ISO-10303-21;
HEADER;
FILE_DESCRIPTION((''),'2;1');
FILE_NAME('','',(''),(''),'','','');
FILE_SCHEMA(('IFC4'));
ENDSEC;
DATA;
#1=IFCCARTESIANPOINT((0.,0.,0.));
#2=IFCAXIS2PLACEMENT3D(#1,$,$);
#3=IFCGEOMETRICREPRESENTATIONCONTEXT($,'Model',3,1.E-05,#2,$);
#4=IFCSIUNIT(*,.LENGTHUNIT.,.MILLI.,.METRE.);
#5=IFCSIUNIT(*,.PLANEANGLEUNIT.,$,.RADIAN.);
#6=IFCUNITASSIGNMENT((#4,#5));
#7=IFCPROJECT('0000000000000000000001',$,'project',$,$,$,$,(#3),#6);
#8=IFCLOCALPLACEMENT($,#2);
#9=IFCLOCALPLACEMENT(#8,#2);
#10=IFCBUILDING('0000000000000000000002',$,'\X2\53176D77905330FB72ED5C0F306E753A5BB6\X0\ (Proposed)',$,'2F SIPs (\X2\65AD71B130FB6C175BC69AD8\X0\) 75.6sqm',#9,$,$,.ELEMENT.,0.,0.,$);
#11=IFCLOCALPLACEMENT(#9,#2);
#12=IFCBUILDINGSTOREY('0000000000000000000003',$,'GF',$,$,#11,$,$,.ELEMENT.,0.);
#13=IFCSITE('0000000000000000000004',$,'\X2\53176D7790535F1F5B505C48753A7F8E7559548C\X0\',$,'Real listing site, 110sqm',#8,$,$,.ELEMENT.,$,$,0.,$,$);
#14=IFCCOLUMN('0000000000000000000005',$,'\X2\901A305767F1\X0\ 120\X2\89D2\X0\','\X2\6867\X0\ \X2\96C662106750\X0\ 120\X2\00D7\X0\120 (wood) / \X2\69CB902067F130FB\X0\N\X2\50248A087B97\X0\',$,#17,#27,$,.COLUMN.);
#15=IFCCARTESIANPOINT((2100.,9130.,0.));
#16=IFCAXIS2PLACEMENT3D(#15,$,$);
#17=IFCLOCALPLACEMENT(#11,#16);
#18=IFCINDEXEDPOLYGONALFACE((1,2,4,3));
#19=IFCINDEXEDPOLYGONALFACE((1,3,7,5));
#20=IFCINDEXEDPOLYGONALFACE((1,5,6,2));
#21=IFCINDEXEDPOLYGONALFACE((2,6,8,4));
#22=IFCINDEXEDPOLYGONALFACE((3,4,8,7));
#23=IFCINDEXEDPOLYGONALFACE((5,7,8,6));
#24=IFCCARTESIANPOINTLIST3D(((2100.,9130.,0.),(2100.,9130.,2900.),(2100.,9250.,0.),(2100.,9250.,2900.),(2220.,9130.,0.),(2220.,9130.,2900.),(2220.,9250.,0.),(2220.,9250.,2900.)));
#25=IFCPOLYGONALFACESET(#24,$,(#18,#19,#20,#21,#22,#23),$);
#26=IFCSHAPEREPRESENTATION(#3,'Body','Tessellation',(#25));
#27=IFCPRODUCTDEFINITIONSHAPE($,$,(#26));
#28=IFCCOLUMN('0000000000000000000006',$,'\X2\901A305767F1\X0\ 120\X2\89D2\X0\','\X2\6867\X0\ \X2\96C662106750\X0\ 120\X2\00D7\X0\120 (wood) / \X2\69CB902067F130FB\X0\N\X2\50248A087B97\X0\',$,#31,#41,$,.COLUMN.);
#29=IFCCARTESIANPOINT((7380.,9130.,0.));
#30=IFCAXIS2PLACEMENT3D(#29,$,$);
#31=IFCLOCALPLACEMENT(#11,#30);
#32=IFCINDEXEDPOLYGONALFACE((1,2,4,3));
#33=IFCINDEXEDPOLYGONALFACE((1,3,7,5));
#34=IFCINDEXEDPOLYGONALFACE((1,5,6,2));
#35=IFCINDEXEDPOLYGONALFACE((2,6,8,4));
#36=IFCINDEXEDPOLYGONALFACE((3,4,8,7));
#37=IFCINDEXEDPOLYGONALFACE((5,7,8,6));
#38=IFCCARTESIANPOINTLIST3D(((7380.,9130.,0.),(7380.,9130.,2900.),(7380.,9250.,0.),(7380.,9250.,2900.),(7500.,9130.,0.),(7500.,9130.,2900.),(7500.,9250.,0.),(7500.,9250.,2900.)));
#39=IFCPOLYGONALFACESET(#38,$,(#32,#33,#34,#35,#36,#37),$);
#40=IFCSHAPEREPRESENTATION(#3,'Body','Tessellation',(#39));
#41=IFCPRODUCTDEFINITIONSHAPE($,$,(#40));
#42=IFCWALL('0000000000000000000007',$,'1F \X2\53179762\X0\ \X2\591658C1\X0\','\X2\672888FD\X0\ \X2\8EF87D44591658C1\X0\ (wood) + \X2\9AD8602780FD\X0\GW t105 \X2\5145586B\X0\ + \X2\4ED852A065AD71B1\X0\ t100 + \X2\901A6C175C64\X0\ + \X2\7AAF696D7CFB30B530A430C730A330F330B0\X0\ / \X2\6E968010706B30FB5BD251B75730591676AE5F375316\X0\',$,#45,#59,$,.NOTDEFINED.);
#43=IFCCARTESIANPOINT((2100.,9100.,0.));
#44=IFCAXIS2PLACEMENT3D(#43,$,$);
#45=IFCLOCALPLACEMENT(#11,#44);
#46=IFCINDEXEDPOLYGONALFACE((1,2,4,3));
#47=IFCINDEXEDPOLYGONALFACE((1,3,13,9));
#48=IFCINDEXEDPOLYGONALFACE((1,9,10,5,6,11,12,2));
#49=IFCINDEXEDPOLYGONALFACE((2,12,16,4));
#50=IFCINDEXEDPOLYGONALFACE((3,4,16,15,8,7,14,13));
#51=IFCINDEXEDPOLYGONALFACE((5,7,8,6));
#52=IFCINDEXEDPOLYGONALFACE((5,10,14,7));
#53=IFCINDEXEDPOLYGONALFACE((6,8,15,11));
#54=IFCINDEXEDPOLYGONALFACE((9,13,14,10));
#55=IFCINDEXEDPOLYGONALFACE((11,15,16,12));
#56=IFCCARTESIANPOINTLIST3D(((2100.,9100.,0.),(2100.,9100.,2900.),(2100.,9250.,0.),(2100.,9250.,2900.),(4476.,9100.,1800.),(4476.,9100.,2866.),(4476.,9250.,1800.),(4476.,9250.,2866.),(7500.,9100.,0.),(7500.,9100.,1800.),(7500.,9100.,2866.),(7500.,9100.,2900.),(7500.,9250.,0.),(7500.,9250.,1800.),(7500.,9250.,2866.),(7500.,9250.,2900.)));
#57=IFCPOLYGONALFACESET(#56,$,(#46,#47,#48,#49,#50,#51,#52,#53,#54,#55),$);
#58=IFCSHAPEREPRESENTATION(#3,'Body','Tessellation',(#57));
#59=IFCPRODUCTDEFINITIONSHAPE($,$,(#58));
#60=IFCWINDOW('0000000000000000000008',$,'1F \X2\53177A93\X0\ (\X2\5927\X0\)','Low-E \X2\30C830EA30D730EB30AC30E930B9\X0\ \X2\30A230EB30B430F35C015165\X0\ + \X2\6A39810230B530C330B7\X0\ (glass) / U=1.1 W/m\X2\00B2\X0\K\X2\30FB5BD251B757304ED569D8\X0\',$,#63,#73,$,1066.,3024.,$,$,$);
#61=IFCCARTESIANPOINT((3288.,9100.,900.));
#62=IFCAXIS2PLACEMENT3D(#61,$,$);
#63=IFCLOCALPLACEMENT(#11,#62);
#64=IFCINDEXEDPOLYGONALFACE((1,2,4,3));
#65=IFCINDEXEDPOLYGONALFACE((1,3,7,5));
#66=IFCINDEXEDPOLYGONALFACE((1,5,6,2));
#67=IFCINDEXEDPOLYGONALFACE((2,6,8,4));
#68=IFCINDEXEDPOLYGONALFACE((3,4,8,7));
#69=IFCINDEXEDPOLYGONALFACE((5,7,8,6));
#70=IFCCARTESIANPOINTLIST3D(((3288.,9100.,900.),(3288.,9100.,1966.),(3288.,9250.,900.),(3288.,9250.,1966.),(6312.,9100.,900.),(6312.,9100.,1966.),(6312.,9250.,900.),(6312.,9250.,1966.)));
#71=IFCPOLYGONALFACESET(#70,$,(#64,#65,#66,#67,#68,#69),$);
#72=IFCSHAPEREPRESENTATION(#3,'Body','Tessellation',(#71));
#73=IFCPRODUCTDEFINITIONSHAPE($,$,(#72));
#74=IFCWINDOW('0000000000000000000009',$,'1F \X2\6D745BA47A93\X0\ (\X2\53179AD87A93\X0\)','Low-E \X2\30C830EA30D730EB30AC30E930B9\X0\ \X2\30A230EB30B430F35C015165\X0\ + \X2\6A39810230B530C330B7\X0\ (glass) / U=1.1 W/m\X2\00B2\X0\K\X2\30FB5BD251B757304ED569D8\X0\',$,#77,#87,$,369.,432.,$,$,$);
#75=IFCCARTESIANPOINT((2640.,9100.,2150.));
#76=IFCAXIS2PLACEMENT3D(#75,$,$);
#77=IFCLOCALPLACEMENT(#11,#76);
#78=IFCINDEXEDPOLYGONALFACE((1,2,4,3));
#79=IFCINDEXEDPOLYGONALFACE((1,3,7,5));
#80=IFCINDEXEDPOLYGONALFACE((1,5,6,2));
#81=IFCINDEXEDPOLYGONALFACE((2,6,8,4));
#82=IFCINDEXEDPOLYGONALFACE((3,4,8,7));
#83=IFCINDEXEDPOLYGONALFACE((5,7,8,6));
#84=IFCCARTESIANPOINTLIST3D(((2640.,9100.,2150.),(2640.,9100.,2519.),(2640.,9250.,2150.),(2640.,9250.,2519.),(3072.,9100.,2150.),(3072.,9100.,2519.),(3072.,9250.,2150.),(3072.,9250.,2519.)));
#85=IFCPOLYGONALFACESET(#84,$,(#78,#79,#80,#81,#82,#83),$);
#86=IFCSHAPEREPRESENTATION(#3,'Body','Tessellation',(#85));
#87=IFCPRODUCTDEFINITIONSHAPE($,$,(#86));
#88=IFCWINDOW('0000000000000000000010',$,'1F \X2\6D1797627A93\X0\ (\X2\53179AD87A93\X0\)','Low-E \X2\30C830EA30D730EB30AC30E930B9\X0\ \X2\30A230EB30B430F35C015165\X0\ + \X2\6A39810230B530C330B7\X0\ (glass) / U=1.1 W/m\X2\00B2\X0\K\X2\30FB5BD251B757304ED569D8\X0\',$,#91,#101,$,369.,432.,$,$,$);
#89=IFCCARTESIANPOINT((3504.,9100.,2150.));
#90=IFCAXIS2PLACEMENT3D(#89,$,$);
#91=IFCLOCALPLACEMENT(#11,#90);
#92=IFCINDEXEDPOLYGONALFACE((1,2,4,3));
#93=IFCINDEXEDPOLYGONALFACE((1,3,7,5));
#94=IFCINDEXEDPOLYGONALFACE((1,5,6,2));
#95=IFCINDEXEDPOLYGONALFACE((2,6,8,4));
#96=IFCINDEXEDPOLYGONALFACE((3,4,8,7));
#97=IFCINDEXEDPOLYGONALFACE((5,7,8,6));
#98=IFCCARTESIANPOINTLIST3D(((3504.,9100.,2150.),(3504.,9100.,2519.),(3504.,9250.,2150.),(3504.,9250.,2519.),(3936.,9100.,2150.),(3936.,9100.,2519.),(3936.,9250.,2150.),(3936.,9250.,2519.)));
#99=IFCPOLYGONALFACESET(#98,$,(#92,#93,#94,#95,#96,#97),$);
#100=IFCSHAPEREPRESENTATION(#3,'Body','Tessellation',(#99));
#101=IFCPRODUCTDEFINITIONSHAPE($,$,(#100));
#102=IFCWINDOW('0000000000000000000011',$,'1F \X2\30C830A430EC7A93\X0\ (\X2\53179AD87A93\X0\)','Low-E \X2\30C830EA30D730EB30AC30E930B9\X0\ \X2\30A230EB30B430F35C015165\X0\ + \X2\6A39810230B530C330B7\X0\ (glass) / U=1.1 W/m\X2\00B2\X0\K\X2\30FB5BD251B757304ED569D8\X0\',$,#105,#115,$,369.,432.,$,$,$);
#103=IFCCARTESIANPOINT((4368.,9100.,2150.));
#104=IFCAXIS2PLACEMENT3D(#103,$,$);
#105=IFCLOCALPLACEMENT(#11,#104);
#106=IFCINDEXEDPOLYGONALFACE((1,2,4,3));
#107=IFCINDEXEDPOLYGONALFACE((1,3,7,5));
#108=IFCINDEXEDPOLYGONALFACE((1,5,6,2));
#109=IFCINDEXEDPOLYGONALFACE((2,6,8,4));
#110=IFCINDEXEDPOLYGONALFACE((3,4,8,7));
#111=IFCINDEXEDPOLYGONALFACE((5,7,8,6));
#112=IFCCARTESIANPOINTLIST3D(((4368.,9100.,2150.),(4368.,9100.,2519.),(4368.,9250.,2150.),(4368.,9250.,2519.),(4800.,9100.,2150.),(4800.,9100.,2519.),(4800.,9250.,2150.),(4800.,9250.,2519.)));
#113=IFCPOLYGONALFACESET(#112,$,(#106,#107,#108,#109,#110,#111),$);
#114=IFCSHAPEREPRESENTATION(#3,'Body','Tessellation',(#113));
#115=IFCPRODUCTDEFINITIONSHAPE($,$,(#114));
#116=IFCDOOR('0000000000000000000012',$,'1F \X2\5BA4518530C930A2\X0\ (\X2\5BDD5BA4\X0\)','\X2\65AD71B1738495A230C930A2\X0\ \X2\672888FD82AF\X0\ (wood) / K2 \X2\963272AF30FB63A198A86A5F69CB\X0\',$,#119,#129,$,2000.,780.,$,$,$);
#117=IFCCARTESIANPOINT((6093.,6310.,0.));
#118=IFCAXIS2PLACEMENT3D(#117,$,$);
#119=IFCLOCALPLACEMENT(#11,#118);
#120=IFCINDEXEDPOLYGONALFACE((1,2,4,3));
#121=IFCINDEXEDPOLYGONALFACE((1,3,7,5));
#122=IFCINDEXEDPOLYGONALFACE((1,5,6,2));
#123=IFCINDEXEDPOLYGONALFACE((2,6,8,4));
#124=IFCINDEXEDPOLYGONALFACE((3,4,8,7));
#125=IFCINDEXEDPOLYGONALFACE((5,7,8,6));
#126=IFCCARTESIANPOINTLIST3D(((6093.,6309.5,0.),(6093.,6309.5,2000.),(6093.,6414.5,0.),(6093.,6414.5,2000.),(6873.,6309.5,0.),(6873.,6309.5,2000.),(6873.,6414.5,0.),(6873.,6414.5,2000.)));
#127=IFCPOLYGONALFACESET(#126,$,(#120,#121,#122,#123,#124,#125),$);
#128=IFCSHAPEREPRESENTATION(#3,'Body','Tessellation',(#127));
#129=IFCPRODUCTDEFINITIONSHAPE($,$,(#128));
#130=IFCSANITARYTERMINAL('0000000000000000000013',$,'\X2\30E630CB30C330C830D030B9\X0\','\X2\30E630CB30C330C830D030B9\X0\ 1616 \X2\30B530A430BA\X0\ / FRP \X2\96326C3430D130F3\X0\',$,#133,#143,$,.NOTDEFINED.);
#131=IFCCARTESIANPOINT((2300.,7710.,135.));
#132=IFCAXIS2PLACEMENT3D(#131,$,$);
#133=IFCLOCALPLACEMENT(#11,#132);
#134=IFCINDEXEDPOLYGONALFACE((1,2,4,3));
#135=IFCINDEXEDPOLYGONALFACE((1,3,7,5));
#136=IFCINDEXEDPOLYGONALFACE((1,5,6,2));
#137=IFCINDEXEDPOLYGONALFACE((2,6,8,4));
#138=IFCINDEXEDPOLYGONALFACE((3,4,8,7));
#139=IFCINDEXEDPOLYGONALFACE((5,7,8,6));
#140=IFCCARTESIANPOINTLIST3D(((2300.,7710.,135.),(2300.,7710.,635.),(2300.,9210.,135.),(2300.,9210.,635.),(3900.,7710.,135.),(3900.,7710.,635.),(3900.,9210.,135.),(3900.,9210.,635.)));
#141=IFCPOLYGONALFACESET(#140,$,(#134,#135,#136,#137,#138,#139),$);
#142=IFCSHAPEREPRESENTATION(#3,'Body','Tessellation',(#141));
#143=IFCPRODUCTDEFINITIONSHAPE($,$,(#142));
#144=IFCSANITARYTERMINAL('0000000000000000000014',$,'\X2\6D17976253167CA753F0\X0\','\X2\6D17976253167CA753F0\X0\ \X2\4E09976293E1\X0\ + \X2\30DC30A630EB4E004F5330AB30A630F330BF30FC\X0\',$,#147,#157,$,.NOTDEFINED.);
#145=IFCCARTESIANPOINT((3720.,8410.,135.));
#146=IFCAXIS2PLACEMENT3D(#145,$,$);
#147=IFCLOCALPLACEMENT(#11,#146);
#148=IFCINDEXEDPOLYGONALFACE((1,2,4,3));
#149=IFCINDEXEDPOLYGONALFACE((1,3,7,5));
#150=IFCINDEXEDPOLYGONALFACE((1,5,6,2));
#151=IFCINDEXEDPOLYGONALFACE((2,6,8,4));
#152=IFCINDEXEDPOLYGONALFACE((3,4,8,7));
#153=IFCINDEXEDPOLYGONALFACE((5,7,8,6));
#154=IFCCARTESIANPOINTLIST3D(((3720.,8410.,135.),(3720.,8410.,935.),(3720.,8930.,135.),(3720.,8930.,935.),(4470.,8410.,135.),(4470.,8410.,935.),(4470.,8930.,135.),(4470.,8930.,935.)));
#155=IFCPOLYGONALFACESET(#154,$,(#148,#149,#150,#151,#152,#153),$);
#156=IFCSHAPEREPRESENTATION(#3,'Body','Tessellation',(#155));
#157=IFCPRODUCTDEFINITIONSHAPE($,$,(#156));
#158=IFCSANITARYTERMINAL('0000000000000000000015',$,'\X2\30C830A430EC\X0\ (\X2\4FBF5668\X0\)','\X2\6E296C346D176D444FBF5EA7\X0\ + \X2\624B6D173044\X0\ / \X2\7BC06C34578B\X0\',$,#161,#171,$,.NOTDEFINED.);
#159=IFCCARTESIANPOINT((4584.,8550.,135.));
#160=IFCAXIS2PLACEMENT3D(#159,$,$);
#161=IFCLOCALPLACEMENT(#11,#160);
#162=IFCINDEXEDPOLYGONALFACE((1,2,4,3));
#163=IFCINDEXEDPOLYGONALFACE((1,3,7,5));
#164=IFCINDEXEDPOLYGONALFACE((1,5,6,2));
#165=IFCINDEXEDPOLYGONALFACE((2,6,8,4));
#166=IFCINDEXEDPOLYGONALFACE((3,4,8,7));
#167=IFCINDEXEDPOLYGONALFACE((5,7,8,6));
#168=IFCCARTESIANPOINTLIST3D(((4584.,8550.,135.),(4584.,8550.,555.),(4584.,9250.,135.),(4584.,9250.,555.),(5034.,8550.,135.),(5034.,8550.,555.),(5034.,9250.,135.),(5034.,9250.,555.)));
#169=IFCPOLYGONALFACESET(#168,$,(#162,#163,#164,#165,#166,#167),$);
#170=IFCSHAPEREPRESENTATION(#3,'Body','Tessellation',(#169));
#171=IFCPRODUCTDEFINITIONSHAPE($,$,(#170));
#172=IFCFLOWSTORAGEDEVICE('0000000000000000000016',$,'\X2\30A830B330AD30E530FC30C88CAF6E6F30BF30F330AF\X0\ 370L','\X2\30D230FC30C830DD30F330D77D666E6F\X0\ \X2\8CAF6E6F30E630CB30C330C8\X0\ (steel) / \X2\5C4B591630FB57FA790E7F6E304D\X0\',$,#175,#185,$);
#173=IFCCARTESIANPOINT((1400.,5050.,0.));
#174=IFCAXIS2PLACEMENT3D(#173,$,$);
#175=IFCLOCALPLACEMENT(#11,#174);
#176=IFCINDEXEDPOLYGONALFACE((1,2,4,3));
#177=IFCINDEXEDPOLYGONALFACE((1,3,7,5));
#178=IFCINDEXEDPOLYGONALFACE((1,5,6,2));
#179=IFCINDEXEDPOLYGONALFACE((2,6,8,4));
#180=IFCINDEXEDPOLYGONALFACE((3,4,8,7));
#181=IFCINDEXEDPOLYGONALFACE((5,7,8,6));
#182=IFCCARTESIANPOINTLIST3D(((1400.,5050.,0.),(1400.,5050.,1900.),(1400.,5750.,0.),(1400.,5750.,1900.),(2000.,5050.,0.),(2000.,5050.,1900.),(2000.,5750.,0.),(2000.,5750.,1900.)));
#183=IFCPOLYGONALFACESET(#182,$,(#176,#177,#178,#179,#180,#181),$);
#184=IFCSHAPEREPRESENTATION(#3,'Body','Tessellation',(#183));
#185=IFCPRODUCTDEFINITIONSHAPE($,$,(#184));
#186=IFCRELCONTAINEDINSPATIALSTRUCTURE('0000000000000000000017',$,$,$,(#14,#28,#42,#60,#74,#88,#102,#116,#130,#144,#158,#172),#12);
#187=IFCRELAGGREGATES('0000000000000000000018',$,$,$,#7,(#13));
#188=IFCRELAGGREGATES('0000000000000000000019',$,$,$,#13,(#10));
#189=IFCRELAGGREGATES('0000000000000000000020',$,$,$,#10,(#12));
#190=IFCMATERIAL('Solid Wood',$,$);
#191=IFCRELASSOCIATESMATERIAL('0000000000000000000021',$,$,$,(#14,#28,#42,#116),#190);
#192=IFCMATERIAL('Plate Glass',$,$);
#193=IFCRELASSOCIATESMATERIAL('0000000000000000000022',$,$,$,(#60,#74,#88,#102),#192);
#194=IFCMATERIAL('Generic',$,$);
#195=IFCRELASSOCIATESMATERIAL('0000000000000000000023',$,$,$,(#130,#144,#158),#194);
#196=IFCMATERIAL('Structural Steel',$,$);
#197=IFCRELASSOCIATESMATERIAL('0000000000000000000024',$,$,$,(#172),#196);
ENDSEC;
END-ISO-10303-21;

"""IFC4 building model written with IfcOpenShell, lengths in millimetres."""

from ifc_helpers import new_model, si_unit, frame, frame_2d, origin, place, context, project, spatial, rectangle, extrude, material, element, fill, save


model = new_model("IFC4")

# Units and contexts
model_context = context("Model", 3, precision=1e-05, world=origin())
ifc_project = project(units=[si_unit("LENGTHUNIT", "METRE", prefix="MILLI"), si_unit("PLANEANGLEUNIT", "RADIAN")], contexts=[model_context])

# Site, building, storey
site_placement = place(None, origin())
site = spatial("IfcSite", under=ifc_project, at=site_placement, Name="北海道弟子屈町美留和", ObjectType="Real listing site, 110sqm", CompositionType="ELEMENT", RefElevation=0.0)
building_placement = place(site_placement, origin())
building = spatial("IfcBuilding", under=site, at=building_placement, Name="北海道・狭小の町家 (Proposed)", ObjectType="2F SIPs (断熱・気密高) 75.6sqm", CompositionType="ELEMENT", ElevationOfRefHeight=0.0, ElevationOfTerrain=0.0)
storey_placement = place(building_placement, origin())
storey = spatial("IfcBuildingStorey", under=building, at=storey_placement, Name="GF", CompositionType="ELEMENT", Elevation=0.0)

# Columns
ifc_material_1 = material(Name="Solid Wood")
column_1_placement = place(storey_placement, frame((2100.0, 9130.0, 0.0)))
element("IfcColumn", 1, at=column_1_placement, inside=storey, material=ifc_material_1, Name="通し柱 120角", Description="桧 集成材 120×120 (wood) / 構造柱・N値計算", PredefinedType="COLUMN", context=model_context, shape_type="SweptSolid", body=[
    extrude(rectangle(XDim=120.0, YDim=120.0, at=frame_2d((60.0, 60.0))), frame((2100.0, 9130.0, 0.0)), (0.0, 0.0, 1.0), 2900.0),
])
column_2_placement = place(storey_placement, frame((7380.0, 9130.0, 0.0)))
element("IfcColumn", 2, at=column_2_placement, inside=storey, material=ifc_material_1, Name="通し柱 120角", Description="桧 集成材 120×120 (wood) / 構造柱・N値計算", PredefinedType="COLUMN", context=model_context, shape_type="SweptSolid", body=[
    extrude(rectangle(XDim=120.0, YDim=120.0, at=frame_2d((60.0, 60.0))), frame((7380.0, 9130.0, 0.0)), (0.0, 0.0, 1.0), 2900.0),
])

# Wall, openings, windows
wall_1_placement = place(storey_placement, frame((2100.0, 9100.0, 0.0)))
wall_1 = element("IfcWall", 3, at=wall_1_placement, inside=storey, material=ifc_material_1, Name="1F 北面 外壁", Description="木製 軸組外壁 (wood) + 高性能GW t105 充填 + 付加断熱 t100 + 通気層 + 窯業系サイディング / 準耐火・寒冷地外皮強化", PredefinedType="NOTDEFINED", context=model_context, shape_type="SweptSolid", body=[
    extrude(rectangle(XDim=5400.0, YDim=150.0, at=frame_2d((2700.0, 75.0))), frame((2100.0, 9100.0, 0.0)), (0.0, 0.0, 1.0), 2900.0),
])
opening_1_placement = place(storey_placement, frame((3288.0, 9100.0, 900.0)))
opening_1 = element("IfcOpeningElement", 4, at=opening_1_placement, cuts=wall_1, PredefinedType="NOTDEFINED", context=model_context, shape_type="SweptSolid", body=[
    extrude(rectangle(XDim=3024.0, YDim=150.0, at=frame_2d((1512.0, 75.0))), frame((3288.0, 9100.0, 900.0)), (0.0, 0.0, 1.0), 1066.0),
])
opening_2_placement = place(storey_placement, frame((2640.0, 9100.0, 2150.0)))
opening_2 = element("IfcOpeningElement", 5, at=opening_2_placement, cuts=wall_1, PredefinedType="NOTDEFINED", context=model_context, shape_type="SweptSolid", body=[
    extrude(rectangle(XDim=432.0, YDim=150.0, at=frame_2d((216.0, 75.0))), frame((2640.0, 9100.0, 2150.0)), (0.0, 0.0, 1.0), 369.0),
])
opening_3_placement = place(storey_placement, frame((3504.0, 9100.0, 2150.0)))
opening_3 = element("IfcOpeningElement", 6, at=opening_3_placement, cuts=wall_1, PredefinedType="NOTDEFINED", context=model_context, shape_type="SweptSolid", body=[
    extrude(rectangle(XDim=432.0, YDim=150.0, at=frame_2d((216.0, 75.0))), frame((3504.0, 9100.0, 2150.0)), (0.0, 0.0, 1.0), 369.0),
])
opening_4_placement = place(storey_placement, frame((4368.0, 9100.0, 2150.0)))
opening_4 = element("IfcOpeningElement", 7, at=opening_4_placement, cuts=wall_1, PredefinedType="NOTDEFINED", context=model_context, shape_type="SweptSolid", body=[
    extrude(rectangle(XDim=432.0, YDim=150.0, at=frame_2d((216.0, 75.0))), frame((4368.0, 9100.0, 2150.0)), (0.0, 0.0, 1.0), 369.0),
])
ifc_material_2 = material(Name="Plate Glass")
window_1_placement = place(storey_placement, frame((3288.0, 9100.0, 900.0)))
window_1 = element("IfcWindow", 8, at=window_1_placement, inside=storey, material=ifc_material_2, Name="1F 北窓 (大)", Description="Low-E トリプルガラス アルゴン封入 + 樹脂サッシ (glass) / U=1.1 W/m²K・寒冷地仕様", OverallHeight=1066.0, OverallWidth=3024.0, context=model_context, shape_type="SweptSolid", body=[
    extrude(rectangle(XDim=3024.0, YDim=150.0, at=frame_2d((1512.0, 75.0))), frame((3288.0, 9100.0, 900.0)), (0.0, 0.0, 1.0), 1066.0),
])
fill(opening_1, window_1)
window_2_placement = place(storey_placement, frame((2640.0, 9100.0, 2150.0)))
window_2 = element("IfcWindow", 9, at=window_2_placement, inside=storey, material=ifc_material_2, Name="1F 浴室窓 (北高窓)", Description="Low-E トリプルガラス アルゴン封入 + 樹脂サッシ (glass) / U=1.1 W/m²K・寒冷地仕様", OverallHeight=369.0, OverallWidth=432.0, context=model_context, shape_type="SweptSolid", body=[
    extrude(rectangle(XDim=432.0, YDim=150.0, at=frame_2d((216.0, 75.0))), frame((2640.0, 9100.0, 2150.0)), (0.0, 0.0, 1.0), 369.0),
])
fill(opening_2, window_2)
window_3_placement = place(storey_placement, frame((3504.0, 9100.0, 2150.0)))
window_3 = element("IfcWindow", 10, at=window_3_placement, inside=storey, material=ifc_material_2, Name="1F 洗面窓 (北高窓)", Description="Low-E トリプルガラス アルゴン封入 + 樹脂サッシ (glass) / U=1.1 W/m²K・寒冷地仕様", OverallHeight=369.0, OverallWidth=432.0, context=model_context, shape_type="SweptSolid", body=[
    extrude(rectangle(XDim=432.0, YDim=150.0, at=frame_2d((216.0, 75.0))), frame((3504.0, 9100.0, 2150.0)), (0.0, 0.0, 1.0), 369.0),
])
fill(opening_3, window_3)
window_4_placement = place(storey_placement, frame((4368.0, 9100.0, 2150.0)))
window_4 = element("IfcWindow", 11, at=window_4_placement, inside=storey, material=ifc_material_2, Name="1F トイレ窓 (北高窓)", Description="Low-E トリプルガラス アルゴン封入 + 樹脂サッシ (glass) / U=1.1 W/m²K・寒冷地仕様", OverallHeight=369.0, OverallWidth=432.0, context=model_context, shape_type="SweptSolid", body=[
    extrude(rectangle(XDim=432.0, YDim=150.0, at=frame_2d((216.0, 75.0))), frame((4368.0, 9100.0, 2150.0)), (0.0, 0.0, 1.0), 369.0),
])
fill(opening_4, window_4)

# Door
door_1_placement = place(storey_placement, frame((6093.0, 6310.0, 0.0)))
element("IfcDoor", 12, at=door_1_placement, inside=storey, material=ifc_material_1, Name="1F 室内ドア (寝室)", Description="断熱玄関ドア 木製芯 (wood) / K2 防犯・採風機構", OverallHeight=2000.0, OverallWidth=780.0, context=model_context, shape_type="SweptSolid", body=[
    extrude(rectangle(XDim=780.0, YDim=105.0, at=frame_2d((390.0, 52.0))), frame((6093.0, 6310.0, 0.0)), (0.0, 0.0, 1.0), 2000.0),
])

# Sanitary terminals
ifc_material_3 = material(Name="Generic")
sanitary_terminal_1_placement = place(storey_placement, frame((2300.0, 7710.0, 135.0)))
element("IfcSanitaryTerminal", 13, at=sanitary_terminal_1_placement, inside=storey, material=ifc_material_3, Name="ユニットバス", Description="ユニットバス 1616 サイズ / FRP 防水パン", PredefinedType="NOTDEFINED", context=model_context, shape_type="SweptSolid", body=[
    extrude(rectangle(XDim=1600.0, YDim=1500.0, at=frame_2d((800.0, 750.0))), frame((2300.0, 7710.0, 135.0)), (0.0, 0.0, 1.0), 500.0),
])
sanitary_terminal_2_placement = place(storey_placement, frame((3720.0, 8410.0, 135.0)))
element("IfcSanitaryTerminal", 14, at=sanitary_terminal_2_placement, inside=storey, material=ifc_material_3, Name="洗面化粧台", Description="洗面化粧台 三面鏡 + ボウル一体カウンター", PredefinedType="NOTDEFINED", context=model_context, shape_type="SweptSolid", body=[
    extrude(rectangle(XDim=750.0, YDim=520.0, at=frame_2d((375.0, 260.0))), frame((3720.0, 8410.0, 135.0)), (0.0, 0.0, 1.0), 800.0),
])
sanitary_terminal_3_placement = place(storey_placement, frame((4584.0, 8550.0, 135.0)))
element("IfcSanitaryTerminal", 15, at=sanitary_terminal_3_placement, inside=storey, material=ifc_material_3, Name="トイレ (便器)", Description="温水洗浄便座 + 手洗い / 節水型", PredefinedType="NOTDEFINED", context=model_context, shape_type="SweptSolid", body=[
    extrude(rectangle(XDim=450.0, YDim=700.0, at=frame_2d((225.0, 350.0))), frame((4584.0, 8550.0, 135.0)), (0.0, 0.0, 1.0), 420.0),
])

# Flow storage device
ifc_material_4 = material(Name="Structural Steel")
flow_storage_device_placement = place(storey_placement, frame((1400.0, 5050.0, 0.0)))
element("IfcFlowStorageDevice", 16, at=flow_storage_device_placement, inside=storey, material=ifc_material_4, Name="エコキュート貯湯タンク 370L", Description="ヒートポンプ給湯 貯湯ユニット (steel) / 屋外・基礎置き", context=model_context, shape_type="SweptSolid", body=[
    extrude(rectangle(XDim=600.0, YDim=700.0, at=frame_2d((300.0, 350.0))), frame((1400.0, 5050.0, 0.0)), (0.0, 0.0, 1.0), 1900.0),
])

save(model, "model.ifc")
